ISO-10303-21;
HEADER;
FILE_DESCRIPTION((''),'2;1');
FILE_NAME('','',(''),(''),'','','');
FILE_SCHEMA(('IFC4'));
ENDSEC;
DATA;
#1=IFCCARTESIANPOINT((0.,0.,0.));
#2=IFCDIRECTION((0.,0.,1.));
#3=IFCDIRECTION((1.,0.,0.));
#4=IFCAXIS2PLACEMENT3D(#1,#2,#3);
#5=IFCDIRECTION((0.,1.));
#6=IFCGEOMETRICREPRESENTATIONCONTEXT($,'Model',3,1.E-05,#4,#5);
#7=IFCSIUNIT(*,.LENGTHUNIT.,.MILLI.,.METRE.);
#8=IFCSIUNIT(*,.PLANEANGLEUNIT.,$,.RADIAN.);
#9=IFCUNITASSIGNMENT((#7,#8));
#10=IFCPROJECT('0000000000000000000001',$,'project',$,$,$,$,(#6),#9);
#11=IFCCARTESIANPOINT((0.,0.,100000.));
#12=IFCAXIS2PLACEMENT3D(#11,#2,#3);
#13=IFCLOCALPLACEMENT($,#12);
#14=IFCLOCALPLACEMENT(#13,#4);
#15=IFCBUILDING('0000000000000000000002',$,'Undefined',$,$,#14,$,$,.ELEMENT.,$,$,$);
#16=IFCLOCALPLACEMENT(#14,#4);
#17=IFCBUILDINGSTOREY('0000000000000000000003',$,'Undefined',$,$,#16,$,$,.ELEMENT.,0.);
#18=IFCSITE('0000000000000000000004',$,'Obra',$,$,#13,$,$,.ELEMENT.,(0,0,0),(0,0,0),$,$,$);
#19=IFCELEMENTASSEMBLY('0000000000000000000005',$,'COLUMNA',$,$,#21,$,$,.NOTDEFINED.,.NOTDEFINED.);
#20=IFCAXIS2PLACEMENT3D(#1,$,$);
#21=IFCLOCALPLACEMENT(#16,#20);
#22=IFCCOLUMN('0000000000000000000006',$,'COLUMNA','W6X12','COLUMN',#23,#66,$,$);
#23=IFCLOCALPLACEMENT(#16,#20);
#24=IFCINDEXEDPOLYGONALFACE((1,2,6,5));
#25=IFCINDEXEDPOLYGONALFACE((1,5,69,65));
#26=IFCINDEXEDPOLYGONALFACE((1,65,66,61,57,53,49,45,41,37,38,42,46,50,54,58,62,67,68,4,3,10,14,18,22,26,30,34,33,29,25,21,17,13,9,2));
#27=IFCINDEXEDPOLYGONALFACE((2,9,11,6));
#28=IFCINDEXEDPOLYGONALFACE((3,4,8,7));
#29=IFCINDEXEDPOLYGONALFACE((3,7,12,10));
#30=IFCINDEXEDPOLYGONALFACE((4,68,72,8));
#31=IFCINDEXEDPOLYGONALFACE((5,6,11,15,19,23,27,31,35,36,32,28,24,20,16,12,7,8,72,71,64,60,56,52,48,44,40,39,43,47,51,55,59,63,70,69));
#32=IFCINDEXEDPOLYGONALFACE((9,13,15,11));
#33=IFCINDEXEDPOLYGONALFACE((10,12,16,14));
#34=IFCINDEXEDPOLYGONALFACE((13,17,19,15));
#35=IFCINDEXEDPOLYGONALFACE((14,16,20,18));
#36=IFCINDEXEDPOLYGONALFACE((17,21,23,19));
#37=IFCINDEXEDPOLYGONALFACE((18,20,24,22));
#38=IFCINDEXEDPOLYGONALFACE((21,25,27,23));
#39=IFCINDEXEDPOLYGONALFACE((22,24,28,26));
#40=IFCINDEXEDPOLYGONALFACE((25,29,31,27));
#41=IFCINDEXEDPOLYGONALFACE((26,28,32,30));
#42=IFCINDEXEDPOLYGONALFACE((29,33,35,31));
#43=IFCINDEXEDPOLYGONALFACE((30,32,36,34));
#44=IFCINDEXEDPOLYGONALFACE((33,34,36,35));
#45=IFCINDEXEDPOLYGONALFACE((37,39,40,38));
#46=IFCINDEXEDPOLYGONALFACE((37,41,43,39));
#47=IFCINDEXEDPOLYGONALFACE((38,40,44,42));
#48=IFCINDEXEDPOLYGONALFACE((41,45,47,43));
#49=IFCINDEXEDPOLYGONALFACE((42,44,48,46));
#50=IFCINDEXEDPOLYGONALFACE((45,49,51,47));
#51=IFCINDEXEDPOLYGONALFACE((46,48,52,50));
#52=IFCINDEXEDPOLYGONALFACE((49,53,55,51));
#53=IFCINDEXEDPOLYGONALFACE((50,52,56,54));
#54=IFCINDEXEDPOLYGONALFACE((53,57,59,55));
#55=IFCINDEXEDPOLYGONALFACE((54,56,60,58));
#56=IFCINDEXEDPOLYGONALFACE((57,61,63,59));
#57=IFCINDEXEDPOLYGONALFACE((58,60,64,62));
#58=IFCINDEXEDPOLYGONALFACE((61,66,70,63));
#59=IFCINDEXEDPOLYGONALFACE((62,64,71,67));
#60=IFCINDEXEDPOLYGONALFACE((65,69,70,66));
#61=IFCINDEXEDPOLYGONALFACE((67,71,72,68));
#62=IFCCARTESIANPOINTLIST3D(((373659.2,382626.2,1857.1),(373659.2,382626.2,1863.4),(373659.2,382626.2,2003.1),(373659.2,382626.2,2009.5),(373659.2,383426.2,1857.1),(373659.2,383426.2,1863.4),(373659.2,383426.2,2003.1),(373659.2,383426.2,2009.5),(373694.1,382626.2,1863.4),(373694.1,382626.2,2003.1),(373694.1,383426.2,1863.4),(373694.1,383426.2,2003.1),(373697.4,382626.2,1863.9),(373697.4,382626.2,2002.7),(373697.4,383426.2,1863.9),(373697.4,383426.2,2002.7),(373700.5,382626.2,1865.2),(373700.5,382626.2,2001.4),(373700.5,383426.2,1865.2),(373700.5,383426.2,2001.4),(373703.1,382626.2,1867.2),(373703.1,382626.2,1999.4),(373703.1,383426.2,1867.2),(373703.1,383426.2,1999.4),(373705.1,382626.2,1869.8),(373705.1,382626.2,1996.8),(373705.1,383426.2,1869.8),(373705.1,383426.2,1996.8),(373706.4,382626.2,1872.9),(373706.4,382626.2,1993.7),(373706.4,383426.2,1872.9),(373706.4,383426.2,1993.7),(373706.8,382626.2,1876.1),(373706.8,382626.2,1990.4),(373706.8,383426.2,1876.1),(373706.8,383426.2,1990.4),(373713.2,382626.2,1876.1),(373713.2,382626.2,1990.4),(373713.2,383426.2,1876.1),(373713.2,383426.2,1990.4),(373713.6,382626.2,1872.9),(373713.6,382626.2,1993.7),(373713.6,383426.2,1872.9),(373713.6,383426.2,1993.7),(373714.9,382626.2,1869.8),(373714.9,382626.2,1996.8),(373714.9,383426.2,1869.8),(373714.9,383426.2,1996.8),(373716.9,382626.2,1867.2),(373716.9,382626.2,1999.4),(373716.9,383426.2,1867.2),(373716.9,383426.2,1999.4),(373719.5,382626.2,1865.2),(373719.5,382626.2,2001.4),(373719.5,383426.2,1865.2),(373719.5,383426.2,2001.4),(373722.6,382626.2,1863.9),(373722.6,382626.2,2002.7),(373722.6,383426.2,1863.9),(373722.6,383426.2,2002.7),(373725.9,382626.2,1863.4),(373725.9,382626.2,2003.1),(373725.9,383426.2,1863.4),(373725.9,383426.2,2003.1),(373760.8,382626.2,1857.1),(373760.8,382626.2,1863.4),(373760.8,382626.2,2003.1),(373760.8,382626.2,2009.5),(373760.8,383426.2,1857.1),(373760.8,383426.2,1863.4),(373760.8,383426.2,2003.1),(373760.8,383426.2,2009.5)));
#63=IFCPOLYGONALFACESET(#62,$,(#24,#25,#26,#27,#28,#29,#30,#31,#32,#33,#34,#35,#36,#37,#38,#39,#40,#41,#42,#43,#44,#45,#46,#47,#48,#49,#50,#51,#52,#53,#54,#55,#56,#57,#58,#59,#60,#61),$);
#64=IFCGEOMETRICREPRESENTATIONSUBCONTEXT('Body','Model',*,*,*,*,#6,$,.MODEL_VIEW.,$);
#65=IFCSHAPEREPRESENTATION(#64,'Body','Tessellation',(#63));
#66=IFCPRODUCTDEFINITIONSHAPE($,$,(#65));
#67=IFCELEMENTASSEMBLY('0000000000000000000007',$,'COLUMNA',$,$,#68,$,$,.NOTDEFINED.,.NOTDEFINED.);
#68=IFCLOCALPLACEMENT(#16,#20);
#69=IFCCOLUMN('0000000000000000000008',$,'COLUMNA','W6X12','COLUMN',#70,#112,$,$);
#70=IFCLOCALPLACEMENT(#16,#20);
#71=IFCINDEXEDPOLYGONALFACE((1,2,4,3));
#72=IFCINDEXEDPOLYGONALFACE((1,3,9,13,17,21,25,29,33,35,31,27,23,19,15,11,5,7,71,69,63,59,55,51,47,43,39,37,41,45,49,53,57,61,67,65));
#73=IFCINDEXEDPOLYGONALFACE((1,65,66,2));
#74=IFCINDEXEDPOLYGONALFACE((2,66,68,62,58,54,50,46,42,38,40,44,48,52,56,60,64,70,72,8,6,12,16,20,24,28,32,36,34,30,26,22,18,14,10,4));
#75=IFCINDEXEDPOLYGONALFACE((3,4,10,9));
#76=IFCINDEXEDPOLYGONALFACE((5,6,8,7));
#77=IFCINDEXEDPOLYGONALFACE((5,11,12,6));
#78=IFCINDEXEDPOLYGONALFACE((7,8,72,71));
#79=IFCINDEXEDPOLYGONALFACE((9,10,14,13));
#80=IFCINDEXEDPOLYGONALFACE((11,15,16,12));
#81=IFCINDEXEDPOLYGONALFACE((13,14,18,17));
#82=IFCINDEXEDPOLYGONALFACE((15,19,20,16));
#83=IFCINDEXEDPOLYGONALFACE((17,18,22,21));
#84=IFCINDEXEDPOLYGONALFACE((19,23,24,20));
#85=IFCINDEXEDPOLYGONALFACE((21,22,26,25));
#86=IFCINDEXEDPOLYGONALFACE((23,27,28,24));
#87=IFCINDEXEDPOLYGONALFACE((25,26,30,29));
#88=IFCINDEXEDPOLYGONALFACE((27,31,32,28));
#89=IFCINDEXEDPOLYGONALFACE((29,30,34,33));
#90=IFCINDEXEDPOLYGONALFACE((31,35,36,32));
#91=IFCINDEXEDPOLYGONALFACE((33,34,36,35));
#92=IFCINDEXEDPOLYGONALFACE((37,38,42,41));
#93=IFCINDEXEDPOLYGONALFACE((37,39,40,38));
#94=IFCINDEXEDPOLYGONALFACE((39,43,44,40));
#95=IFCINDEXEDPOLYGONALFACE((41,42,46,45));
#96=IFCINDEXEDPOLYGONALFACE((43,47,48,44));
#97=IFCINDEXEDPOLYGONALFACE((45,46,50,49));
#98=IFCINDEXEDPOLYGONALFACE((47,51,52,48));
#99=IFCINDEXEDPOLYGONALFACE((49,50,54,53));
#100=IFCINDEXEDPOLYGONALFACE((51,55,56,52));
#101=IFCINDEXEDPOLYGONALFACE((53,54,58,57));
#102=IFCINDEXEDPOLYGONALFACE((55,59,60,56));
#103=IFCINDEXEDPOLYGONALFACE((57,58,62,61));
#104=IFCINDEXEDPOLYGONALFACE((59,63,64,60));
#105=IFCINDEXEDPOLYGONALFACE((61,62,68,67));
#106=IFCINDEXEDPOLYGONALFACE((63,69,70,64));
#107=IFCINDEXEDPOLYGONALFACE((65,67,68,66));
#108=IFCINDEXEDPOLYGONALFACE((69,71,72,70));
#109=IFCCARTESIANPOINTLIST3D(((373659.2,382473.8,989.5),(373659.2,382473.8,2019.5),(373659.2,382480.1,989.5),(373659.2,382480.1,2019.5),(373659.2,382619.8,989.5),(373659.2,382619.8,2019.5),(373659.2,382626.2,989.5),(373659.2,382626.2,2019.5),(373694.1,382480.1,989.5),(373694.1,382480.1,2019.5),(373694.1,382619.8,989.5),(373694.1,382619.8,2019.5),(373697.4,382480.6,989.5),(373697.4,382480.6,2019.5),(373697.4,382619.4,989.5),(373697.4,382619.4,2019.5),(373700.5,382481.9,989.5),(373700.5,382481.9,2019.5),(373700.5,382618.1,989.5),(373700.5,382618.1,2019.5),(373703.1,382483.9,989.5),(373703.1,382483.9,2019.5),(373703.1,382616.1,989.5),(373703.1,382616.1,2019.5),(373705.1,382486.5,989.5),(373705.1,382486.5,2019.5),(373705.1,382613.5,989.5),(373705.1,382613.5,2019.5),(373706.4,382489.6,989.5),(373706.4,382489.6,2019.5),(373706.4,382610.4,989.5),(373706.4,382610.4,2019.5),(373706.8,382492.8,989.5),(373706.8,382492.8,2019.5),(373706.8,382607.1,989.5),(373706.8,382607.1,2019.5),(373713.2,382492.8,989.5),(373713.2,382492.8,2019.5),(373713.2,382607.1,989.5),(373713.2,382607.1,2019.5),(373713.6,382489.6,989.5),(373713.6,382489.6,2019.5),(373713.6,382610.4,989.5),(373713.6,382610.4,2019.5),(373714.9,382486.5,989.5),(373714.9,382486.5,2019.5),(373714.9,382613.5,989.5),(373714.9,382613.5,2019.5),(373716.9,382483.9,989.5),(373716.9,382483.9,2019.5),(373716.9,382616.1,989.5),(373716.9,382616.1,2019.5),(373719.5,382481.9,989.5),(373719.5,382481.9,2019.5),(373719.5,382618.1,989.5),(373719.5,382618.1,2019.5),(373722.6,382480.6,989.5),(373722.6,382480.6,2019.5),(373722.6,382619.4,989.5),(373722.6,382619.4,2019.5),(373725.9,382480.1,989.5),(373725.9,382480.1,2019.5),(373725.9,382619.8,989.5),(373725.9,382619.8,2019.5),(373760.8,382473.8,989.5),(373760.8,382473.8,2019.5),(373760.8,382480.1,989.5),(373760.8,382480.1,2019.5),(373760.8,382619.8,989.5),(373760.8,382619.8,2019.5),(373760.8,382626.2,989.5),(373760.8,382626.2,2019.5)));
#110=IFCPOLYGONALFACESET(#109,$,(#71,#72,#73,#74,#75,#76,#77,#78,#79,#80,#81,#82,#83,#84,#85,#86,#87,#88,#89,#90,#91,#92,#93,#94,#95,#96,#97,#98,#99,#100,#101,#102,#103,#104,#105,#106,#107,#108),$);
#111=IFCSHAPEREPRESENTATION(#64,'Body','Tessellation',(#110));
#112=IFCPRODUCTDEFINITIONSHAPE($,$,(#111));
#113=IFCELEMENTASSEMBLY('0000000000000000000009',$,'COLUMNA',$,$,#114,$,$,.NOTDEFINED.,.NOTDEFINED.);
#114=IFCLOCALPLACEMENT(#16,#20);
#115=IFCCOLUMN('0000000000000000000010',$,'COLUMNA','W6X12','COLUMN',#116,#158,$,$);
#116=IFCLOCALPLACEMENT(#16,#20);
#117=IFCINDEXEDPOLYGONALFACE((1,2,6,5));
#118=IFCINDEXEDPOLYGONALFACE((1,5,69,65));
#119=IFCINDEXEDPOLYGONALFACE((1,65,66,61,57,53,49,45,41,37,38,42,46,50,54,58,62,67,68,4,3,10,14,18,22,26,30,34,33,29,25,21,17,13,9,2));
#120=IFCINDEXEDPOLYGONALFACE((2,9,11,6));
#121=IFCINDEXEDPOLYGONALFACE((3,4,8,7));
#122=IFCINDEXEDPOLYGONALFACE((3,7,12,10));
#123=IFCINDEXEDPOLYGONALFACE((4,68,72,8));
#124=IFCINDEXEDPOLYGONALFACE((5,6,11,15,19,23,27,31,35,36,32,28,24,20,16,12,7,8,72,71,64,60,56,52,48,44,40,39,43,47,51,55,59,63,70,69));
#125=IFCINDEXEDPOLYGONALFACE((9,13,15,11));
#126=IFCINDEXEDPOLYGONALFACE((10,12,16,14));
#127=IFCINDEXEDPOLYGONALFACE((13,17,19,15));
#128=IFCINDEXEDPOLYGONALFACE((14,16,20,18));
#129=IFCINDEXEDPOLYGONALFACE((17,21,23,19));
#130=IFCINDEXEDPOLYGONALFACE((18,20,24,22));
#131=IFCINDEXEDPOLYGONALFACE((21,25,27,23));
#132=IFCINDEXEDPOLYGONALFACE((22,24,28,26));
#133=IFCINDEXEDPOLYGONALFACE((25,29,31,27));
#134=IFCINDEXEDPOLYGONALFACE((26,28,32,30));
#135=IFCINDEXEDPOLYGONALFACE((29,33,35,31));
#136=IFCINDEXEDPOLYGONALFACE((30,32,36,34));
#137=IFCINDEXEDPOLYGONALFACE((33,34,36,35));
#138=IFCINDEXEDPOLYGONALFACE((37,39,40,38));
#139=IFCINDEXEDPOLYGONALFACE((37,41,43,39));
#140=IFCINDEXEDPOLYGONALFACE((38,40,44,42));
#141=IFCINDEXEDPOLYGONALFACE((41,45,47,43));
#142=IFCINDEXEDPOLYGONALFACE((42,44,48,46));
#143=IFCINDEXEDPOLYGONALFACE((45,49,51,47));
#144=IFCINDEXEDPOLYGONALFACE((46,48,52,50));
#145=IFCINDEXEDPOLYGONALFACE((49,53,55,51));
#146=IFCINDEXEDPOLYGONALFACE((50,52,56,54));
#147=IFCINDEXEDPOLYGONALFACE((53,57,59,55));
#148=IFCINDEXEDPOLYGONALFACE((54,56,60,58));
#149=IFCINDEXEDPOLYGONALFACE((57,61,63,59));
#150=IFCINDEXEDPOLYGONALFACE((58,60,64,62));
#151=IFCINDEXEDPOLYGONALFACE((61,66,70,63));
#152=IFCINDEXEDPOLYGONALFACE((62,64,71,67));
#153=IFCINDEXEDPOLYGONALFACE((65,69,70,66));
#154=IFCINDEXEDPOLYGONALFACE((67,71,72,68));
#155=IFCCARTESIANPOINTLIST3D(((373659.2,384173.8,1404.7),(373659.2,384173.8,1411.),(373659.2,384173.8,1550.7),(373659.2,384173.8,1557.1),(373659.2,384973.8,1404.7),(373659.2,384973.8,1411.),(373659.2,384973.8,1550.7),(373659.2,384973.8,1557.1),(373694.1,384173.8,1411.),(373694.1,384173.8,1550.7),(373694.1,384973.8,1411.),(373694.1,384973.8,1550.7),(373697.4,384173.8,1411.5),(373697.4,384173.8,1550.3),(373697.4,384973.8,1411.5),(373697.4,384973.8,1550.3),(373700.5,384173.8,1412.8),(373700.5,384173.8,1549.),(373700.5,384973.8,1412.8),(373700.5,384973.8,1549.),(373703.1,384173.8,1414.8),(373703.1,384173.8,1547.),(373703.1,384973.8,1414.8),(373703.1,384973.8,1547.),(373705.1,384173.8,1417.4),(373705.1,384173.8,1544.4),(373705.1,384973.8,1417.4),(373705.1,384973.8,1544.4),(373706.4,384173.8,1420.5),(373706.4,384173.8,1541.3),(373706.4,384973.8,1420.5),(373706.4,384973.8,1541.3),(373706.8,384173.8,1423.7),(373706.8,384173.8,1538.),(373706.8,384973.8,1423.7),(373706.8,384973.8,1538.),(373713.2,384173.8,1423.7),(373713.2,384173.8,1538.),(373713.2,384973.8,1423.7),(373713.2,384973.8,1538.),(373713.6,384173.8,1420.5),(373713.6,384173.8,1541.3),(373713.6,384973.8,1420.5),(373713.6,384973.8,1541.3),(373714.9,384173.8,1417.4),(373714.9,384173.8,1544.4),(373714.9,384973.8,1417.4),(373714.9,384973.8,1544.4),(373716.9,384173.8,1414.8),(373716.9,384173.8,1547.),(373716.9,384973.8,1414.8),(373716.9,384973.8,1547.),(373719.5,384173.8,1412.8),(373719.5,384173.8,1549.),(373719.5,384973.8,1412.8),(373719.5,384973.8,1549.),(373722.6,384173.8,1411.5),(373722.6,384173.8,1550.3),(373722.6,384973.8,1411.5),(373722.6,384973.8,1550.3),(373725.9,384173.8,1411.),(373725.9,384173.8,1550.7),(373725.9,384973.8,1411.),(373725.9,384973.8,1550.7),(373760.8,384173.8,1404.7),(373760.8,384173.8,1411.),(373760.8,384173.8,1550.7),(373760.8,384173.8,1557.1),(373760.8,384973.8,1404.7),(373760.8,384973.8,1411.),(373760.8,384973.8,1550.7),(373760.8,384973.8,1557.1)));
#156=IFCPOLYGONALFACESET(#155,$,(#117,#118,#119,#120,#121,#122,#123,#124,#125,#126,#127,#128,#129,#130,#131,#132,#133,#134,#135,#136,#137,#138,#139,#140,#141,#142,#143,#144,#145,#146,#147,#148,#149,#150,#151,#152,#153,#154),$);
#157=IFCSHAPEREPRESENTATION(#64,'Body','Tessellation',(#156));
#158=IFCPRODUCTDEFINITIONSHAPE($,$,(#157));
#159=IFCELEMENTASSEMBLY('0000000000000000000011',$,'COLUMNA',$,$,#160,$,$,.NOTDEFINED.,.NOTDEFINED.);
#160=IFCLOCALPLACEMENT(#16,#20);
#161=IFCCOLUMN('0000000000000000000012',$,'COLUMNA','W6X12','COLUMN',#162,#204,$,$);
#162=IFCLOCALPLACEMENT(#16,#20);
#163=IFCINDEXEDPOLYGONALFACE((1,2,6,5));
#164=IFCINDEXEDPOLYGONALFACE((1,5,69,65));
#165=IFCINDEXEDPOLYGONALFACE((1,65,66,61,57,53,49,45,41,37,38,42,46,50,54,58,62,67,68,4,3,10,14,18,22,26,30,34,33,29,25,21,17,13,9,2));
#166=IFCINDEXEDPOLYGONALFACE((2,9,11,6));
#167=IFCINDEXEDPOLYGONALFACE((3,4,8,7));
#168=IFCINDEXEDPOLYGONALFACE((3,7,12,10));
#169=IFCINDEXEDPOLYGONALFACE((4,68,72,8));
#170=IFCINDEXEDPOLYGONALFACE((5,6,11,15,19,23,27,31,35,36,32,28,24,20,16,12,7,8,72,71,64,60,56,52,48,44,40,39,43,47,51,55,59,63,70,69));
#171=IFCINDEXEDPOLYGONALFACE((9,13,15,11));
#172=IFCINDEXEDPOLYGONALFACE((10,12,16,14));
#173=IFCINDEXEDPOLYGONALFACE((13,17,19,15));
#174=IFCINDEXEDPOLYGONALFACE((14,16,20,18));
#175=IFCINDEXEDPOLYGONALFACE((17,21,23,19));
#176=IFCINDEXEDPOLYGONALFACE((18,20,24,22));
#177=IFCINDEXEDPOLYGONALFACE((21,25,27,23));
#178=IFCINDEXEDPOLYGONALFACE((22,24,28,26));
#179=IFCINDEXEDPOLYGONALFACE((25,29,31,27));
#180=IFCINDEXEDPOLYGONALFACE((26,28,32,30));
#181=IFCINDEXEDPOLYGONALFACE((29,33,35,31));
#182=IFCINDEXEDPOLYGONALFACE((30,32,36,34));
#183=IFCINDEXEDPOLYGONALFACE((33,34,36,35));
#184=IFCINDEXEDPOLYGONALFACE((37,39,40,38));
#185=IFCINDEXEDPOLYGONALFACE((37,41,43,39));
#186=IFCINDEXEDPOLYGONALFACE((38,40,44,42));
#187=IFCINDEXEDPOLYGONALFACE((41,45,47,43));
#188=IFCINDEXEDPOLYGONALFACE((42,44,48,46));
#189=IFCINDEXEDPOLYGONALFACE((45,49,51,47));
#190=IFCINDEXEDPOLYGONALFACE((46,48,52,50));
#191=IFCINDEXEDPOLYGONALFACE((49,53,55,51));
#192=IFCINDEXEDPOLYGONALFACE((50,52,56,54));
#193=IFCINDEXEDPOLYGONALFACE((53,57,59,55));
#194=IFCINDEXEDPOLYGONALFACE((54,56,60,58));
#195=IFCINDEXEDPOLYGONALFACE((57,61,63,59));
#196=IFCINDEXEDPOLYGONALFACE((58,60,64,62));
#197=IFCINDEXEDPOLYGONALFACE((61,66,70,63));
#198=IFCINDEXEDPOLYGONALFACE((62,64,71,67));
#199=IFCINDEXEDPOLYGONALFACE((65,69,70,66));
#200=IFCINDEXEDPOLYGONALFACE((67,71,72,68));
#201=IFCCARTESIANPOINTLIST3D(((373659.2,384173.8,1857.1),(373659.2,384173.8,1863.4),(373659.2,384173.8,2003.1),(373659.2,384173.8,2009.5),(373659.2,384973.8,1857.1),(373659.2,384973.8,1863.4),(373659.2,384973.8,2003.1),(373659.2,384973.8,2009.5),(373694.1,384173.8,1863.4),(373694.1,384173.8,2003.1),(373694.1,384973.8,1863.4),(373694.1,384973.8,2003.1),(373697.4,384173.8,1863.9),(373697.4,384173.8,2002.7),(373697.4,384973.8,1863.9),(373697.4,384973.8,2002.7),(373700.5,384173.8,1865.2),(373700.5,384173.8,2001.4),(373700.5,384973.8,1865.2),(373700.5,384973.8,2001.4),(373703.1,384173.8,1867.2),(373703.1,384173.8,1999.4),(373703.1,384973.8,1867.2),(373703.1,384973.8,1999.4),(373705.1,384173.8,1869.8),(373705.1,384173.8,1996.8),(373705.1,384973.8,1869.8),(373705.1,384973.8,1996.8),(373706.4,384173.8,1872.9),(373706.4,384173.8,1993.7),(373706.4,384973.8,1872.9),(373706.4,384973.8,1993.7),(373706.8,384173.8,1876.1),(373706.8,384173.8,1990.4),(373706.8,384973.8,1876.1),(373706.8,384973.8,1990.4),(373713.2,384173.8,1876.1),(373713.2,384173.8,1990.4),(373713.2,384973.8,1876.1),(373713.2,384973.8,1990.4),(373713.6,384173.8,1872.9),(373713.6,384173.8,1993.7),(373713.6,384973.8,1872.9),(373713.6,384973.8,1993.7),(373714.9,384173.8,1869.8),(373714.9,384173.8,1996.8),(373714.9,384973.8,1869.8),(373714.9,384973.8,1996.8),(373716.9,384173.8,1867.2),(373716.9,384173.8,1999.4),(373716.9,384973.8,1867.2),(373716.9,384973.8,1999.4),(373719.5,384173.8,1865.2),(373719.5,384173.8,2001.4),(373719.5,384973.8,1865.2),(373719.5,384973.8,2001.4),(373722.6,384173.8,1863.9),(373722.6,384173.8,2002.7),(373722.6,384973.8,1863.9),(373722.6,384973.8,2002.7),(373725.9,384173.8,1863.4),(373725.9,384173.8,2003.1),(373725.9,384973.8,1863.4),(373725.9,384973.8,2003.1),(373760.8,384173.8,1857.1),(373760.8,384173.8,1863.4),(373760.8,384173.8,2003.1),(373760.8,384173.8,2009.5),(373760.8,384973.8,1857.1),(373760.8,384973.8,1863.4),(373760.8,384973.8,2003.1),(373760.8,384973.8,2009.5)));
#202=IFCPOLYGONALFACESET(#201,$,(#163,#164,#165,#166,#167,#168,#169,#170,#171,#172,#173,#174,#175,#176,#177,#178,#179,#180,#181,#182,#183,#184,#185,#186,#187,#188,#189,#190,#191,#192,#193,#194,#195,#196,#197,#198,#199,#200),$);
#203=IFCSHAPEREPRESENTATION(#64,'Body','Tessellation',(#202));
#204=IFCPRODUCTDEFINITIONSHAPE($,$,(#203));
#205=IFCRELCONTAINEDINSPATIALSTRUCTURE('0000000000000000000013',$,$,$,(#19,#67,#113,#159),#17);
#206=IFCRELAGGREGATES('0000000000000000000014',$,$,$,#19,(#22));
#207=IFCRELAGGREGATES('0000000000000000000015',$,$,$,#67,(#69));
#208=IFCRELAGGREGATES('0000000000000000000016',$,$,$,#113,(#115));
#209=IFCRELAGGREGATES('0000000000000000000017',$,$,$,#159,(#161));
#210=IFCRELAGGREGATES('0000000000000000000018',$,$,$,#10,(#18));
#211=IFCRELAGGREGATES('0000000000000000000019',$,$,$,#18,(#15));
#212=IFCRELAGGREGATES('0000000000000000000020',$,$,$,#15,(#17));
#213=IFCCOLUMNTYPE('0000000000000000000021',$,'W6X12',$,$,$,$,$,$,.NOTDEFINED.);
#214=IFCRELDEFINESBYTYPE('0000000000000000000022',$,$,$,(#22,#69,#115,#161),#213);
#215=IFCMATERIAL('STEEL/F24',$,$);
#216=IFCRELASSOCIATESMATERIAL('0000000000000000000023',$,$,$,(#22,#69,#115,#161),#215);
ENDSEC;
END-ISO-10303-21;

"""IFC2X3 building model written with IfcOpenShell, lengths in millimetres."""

from ifc_helpers import new_model, si_unit, direction, frame, origin_with_axes, origin_2d_with_axis, place, context, subcontext, project, spatial, i_section, extrude, material, type_object, element, aggregate, save


model = new_model("IFC2X3")

# Units and contexts
model_context = context("Model", 3, precision=1e-05, world=origin_with_axes(), true_north=direction((0.0, 1.0)))
body_context = subcontext(model_context, "Body", "Model", "MODEL_VIEW")
ifc_project = project(units=[si_unit("LENGTHUNIT", "METRE", prefix="MILLI"), si_unit("PLANEANGLEUNIT", "RADIAN")], contexts=[model_context])

# Site, building, storey
site_placement = place(None, frame((0.0, 0.0, 100000.0), z_axis=(0.0, 0.0, 1.0), x_axis=(1.0, 0.0, 0.0)))
site = spatial("IfcSite", under=ifc_project, at=site_placement, Name="Obra", CompositionType="ELEMENT", RefLatitude=(0, 0, 0), RefLongitude=(0, 0, 0))
building_placement = place(site_placement, origin_with_axes())
building = spatial("IfcBuilding", under=site, at=building_placement, Name="Undefined", CompositionType="ELEMENT")
storey_placement = place(building_placement, origin_with_axes())
storey = spatial("IfcBuildingStorey", under=building, at=storey_placement, Name="Undefined", CompositionType="ELEMENT", Elevation=0.0)

# Element assemblies, columns
ifc_material_1 = material(Name="STEEL/F24")
column_type_1 = type_object("IfcColumnType", Name="W6X12", PredefinedType="NOTDEFINED")
assembly_1_placement = place(storey_placement, origin_with_axes())
assembly_1 = element("IfcElementAssembly", 1, at=assembly_1_placement, inside=storey, Name="COLUMNA", AssemblyPlace="NOTDEFINED", PredefinedType="NOTDEFINED")
column_1_placement = place(assembly_1_placement, frame((373710.0, 382626.2, 1933.3), z_axis=(0.0, 1.0, 0.0), x_axis=(0.0, 0.0, -1.0)))
column_1 = element("IfcColumn", 2, at=column_1_placement, type_object=column_type_1, material=ifc_material_1, Name="COLUMNA", Description="W6X12", ObjectType="COLUMN", context=body_context, shape_type="SweptSolid", body=[
    extrude(i_section(OverallWidth=101.6, OverallDepth=152.4, WebThickness=6.3, FlangeThickness=6.3, FilletRadius=12.7, at=origin_2d_with_axis()), frame((0.0, 0.0, 800.0), z_axis=(0.0, 0.0, -1.0), x_axis=(0.0, 1.0, 0.0)), (0.0, 0.0, 1.0), 800.0),
])
aggregate(assembly_1, [column_1])
assembly_2_placement = place(storey_placement, origin_with_axes())
assembly_2 = element("IfcElementAssembly", 3, at=assembly_2_placement, inside=storey, Name="COLUMNA", AssemblyPlace="NOTDEFINED", PredefinedType="NOTDEFINED")
column_2_placement = place(assembly_2_placement, frame((373710.0, 382550.0, 989.5), z_axis=(0.0, 0.0, 1.0), x_axis=(0.0, -1.0, 0.0)))
column_2 = element("IfcColumn", 4, at=column_2_placement, type_object=column_type_1, material=ifc_material_1, Name="COLUMNA", Description="W6X12", ObjectType="COLUMN", context=body_context, shape_type="SweptSolid", body=[
    extrude(i_section(OverallWidth=101.6, OverallDepth=152.4, WebThickness=6.3, FlangeThickness=6.3, FilletRadius=12.7, at=origin_2d_with_axis()), frame((0.0, 0.0, 1030.0), z_axis=(0.0, 0.0, -1.0), x_axis=(0.0, 1.0, 0.0)), (0.0, 0.0, 1.0), 1030.0),
])
aggregate(assembly_2, [column_2])
assembly_3_placement = place(storey_placement, origin_with_axes())
assembly_3 = element("IfcElementAssembly", 5, at=assembly_3_placement, inside=storey, Name="COLUMNA", AssemblyPlace="NOTDEFINED", PredefinedType="NOTDEFINED")
column_3_placement = place(assembly_3_placement, frame((373710.0, 384973.8, 1480.9), z_axis=(0.0, -1.0, 0.0), x_axis=(0.0, 0.0, -1.0)))
column_3 = element("IfcColumn", 6, at=column_3_placement, type_object=column_type_1, material=ifc_material_1, Name="COLUMNA", Description="W6X12", ObjectType="COLUMN", context=body_context, shape_type="SweptSolid", body=[
    extrude(i_section(OverallWidth=101.6, OverallDepth=152.4, WebThickness=6.3, FlangeThickness=6.3, FilletRadius=12.7, at=origin_2d_with_axis()), frame((0.0, 0.0, 800.0), z_axis=(0.0, 0.0, -1.0), x_axis=(0.0, 1.0, 0.0)), (0.0, 0.0, 1.0), 800.0),
])
aggregate(assembly_3, [column_3])
assembly_4_placement = place(storey_placement, origin_with_axes())
assembly_4 = element("IfcElementAssembly", 7, at=assembly_4_placement, inside=storey, Name="COLUMNA", AssemblyPlace="NOTDEFINED", PredefinedType="NOTDEFINED")
column_4_placement = place(assembly_4_placement, frame((373710.0, 384973.8, 1933.3), z_axis=(0.0, -1.0, 0.0), x_axis=(0.0, 0.0, -1.0)))
column_4 = element("IfcColumn", 8, at=column_4_placement, type_object=column_type_1, material=ifc_material_1, Name="COLUMNA", Description="W6X12", ObjectType="COLUMN", context=body_context, shape_type="SweptSolid", body=[
    extrude(i_section(OverallWidth=101.6, OverallDepth=152.4, WebThickness=6.3, FlangeThickness=6.3, FilletRadius=12.7, at=origin_2d_with_axis()), frame((0.0, 0.0, 800.0), z_axis=(0.0, 0.0, -1.0), x_axis=(0.0, 1.0, 0.0)), (0.0, 0.0, 1.0), 800.0),
])
aggregate(assembly_4, [column_4])

save(model, "model.ifc")
